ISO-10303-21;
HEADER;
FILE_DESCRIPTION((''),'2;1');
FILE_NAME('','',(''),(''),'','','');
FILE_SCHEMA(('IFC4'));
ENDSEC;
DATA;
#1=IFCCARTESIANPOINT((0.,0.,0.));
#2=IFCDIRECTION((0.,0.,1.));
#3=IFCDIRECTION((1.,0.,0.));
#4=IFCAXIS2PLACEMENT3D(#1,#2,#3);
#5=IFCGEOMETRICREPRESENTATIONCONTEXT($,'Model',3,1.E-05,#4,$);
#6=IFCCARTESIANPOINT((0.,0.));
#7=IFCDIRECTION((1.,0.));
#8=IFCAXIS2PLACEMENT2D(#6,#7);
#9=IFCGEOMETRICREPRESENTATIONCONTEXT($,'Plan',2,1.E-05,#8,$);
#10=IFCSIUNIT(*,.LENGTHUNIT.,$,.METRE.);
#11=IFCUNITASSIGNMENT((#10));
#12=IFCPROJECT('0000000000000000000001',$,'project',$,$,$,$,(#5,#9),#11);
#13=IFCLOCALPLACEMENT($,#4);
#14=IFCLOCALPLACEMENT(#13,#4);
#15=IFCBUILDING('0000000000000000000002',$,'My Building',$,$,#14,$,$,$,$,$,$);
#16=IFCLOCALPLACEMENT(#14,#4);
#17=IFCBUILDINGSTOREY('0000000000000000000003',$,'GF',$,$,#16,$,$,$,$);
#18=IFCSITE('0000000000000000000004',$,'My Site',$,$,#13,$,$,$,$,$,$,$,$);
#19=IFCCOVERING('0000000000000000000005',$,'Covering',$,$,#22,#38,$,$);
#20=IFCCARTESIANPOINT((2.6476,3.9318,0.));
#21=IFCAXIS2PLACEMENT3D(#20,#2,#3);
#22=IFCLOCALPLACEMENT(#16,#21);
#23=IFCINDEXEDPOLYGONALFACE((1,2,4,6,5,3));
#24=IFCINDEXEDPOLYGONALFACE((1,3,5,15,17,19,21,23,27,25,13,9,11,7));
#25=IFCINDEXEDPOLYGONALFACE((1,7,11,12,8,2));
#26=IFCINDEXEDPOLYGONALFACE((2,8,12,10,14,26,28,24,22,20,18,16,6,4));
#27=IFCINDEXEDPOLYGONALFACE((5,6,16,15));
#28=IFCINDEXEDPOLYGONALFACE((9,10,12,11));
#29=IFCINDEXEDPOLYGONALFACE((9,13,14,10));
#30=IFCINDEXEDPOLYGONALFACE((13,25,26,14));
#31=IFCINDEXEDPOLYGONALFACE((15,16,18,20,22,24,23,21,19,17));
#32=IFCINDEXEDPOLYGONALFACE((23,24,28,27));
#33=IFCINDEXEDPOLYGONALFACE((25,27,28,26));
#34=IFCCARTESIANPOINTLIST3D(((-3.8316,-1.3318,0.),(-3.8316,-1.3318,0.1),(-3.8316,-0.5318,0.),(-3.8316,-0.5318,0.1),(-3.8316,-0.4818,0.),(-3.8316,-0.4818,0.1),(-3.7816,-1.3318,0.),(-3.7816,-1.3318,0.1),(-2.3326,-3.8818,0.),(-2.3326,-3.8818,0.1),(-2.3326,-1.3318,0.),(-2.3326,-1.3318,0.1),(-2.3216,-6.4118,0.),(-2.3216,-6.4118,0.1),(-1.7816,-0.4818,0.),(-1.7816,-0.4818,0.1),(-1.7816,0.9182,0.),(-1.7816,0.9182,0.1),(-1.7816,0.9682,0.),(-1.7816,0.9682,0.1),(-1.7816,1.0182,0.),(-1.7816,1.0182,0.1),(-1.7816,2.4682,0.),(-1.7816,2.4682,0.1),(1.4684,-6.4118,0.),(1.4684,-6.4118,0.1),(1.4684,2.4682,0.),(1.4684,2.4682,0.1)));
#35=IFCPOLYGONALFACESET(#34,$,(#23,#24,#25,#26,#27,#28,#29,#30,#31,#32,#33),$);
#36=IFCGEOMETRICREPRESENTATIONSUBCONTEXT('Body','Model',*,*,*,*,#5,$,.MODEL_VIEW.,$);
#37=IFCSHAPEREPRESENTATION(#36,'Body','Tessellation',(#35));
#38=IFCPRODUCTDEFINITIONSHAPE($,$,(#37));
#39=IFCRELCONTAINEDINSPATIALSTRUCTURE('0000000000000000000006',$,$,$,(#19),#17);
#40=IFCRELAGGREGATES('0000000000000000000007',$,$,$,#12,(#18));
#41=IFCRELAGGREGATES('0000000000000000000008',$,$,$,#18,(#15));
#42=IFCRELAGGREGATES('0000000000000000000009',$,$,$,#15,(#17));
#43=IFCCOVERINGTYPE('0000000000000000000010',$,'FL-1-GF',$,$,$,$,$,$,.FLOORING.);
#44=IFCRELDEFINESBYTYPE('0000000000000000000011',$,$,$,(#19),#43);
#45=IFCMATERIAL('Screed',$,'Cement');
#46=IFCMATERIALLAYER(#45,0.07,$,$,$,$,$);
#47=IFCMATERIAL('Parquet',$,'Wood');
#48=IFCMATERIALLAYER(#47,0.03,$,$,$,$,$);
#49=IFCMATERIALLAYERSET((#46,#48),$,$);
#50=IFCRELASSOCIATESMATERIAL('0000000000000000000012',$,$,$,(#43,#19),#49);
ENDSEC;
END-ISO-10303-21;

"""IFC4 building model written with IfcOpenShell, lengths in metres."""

from ifc_helpers import new_model, si_unit, frame, origin_with_axes, origin_2d_with_axis, place, context, subcontext, project, spatial, line, indexed_curve, outline, extrude, material, layer, layer_set, layer_usage, type_object, element, save


model = new_model("IFC4")

# Units and contexts
model_context = context("Model", 3, precision=1e-05, world=origin_with_axes())
plan_context = context("Plan", 2, precision=1e-05, world=origin_2d_with_axis())
body_context_1 = subcontext(model_context, "Body", "Model", "MODEL_VIEW")
ifc_project = project(units=[si_unit("LENGTHUNIT", "METRE")], contexts=[model_context, plan_context])

# Site, building, storey
site_placement = place(None, origin_with_axes())
site = spatial("IfcSite", under=ifc_project, at=site_placement, Name="My Site")
building_placement = place(site_placement, origin_with_axes())
building = spatial("IfcBuilding", under=site, at=building_placement, Name="My Building")
storey_placement = place(building_placement, origin_with_axes())
storey = spatial("IfcBuildingStorey", under=building, at=storey_placement, Name="GF")

# Covering
ifc_material_1 = material(Name="Screed", Category="Cement")
ifc_layer_1 = layer(ifc_material_1, 0.07)
ifc_material_2 = material(Name="Parquet", Category="Wood")
ifc_layer_2 = layer(ifc_material_2, 0.03)
ifc_layer_set_1 = layer_set([ifc_layer_1, ifc_layer_2])
ifc_layer_usage_1 = layer_usage(ifc_layer_set_1, "AXIS3", "POSITIVE", 0.0)
covering_type = type_object("IfcCoveringType", Name="FL-1-GF", PredefinedType="FLOORING", material=ifc_layer_set_1)
covering_placement = place(storey_placement, frame((2.6476, 3.9318, 0.0), z_axis=(0.0, 0.0, 1.0), x_axis=(1.0, 0.0, 0.0)))
element("IfcCovering", 1, at=covering_placement, inside=storey, type_object=covering_type, material=ifc_layer_usage_1, Name="Covering", context=body_context_1, shape_type="SweptSolid", body=[
    extrude(outline(indexed_curve([(-1.7816, -0.4818), (-1.7816, 0.9182), (-1.7816, 0.9682), (-1.7816, 1.0182), (-1.7816, 2.4682), (1.4684, 2.4682), (1.4684, -6.4118), (-2.3216, -6.4118), (-2.3326, -3.8818), (-2.3326, -1.3318), (-3.7816, -1.3318), (-3.8316, -1.3318), (-3.8316, -0.5318), (-3.8316, -0.4818)], segments=[line(1, 2, 3, 4, 5, 6, 7, 8, 9, 10, 11, 12, 13, 14, 1)])), origin_with_axes(), (0.0, 0.0, 1.0), 0.1),
])

save(model, "model.ifc")
